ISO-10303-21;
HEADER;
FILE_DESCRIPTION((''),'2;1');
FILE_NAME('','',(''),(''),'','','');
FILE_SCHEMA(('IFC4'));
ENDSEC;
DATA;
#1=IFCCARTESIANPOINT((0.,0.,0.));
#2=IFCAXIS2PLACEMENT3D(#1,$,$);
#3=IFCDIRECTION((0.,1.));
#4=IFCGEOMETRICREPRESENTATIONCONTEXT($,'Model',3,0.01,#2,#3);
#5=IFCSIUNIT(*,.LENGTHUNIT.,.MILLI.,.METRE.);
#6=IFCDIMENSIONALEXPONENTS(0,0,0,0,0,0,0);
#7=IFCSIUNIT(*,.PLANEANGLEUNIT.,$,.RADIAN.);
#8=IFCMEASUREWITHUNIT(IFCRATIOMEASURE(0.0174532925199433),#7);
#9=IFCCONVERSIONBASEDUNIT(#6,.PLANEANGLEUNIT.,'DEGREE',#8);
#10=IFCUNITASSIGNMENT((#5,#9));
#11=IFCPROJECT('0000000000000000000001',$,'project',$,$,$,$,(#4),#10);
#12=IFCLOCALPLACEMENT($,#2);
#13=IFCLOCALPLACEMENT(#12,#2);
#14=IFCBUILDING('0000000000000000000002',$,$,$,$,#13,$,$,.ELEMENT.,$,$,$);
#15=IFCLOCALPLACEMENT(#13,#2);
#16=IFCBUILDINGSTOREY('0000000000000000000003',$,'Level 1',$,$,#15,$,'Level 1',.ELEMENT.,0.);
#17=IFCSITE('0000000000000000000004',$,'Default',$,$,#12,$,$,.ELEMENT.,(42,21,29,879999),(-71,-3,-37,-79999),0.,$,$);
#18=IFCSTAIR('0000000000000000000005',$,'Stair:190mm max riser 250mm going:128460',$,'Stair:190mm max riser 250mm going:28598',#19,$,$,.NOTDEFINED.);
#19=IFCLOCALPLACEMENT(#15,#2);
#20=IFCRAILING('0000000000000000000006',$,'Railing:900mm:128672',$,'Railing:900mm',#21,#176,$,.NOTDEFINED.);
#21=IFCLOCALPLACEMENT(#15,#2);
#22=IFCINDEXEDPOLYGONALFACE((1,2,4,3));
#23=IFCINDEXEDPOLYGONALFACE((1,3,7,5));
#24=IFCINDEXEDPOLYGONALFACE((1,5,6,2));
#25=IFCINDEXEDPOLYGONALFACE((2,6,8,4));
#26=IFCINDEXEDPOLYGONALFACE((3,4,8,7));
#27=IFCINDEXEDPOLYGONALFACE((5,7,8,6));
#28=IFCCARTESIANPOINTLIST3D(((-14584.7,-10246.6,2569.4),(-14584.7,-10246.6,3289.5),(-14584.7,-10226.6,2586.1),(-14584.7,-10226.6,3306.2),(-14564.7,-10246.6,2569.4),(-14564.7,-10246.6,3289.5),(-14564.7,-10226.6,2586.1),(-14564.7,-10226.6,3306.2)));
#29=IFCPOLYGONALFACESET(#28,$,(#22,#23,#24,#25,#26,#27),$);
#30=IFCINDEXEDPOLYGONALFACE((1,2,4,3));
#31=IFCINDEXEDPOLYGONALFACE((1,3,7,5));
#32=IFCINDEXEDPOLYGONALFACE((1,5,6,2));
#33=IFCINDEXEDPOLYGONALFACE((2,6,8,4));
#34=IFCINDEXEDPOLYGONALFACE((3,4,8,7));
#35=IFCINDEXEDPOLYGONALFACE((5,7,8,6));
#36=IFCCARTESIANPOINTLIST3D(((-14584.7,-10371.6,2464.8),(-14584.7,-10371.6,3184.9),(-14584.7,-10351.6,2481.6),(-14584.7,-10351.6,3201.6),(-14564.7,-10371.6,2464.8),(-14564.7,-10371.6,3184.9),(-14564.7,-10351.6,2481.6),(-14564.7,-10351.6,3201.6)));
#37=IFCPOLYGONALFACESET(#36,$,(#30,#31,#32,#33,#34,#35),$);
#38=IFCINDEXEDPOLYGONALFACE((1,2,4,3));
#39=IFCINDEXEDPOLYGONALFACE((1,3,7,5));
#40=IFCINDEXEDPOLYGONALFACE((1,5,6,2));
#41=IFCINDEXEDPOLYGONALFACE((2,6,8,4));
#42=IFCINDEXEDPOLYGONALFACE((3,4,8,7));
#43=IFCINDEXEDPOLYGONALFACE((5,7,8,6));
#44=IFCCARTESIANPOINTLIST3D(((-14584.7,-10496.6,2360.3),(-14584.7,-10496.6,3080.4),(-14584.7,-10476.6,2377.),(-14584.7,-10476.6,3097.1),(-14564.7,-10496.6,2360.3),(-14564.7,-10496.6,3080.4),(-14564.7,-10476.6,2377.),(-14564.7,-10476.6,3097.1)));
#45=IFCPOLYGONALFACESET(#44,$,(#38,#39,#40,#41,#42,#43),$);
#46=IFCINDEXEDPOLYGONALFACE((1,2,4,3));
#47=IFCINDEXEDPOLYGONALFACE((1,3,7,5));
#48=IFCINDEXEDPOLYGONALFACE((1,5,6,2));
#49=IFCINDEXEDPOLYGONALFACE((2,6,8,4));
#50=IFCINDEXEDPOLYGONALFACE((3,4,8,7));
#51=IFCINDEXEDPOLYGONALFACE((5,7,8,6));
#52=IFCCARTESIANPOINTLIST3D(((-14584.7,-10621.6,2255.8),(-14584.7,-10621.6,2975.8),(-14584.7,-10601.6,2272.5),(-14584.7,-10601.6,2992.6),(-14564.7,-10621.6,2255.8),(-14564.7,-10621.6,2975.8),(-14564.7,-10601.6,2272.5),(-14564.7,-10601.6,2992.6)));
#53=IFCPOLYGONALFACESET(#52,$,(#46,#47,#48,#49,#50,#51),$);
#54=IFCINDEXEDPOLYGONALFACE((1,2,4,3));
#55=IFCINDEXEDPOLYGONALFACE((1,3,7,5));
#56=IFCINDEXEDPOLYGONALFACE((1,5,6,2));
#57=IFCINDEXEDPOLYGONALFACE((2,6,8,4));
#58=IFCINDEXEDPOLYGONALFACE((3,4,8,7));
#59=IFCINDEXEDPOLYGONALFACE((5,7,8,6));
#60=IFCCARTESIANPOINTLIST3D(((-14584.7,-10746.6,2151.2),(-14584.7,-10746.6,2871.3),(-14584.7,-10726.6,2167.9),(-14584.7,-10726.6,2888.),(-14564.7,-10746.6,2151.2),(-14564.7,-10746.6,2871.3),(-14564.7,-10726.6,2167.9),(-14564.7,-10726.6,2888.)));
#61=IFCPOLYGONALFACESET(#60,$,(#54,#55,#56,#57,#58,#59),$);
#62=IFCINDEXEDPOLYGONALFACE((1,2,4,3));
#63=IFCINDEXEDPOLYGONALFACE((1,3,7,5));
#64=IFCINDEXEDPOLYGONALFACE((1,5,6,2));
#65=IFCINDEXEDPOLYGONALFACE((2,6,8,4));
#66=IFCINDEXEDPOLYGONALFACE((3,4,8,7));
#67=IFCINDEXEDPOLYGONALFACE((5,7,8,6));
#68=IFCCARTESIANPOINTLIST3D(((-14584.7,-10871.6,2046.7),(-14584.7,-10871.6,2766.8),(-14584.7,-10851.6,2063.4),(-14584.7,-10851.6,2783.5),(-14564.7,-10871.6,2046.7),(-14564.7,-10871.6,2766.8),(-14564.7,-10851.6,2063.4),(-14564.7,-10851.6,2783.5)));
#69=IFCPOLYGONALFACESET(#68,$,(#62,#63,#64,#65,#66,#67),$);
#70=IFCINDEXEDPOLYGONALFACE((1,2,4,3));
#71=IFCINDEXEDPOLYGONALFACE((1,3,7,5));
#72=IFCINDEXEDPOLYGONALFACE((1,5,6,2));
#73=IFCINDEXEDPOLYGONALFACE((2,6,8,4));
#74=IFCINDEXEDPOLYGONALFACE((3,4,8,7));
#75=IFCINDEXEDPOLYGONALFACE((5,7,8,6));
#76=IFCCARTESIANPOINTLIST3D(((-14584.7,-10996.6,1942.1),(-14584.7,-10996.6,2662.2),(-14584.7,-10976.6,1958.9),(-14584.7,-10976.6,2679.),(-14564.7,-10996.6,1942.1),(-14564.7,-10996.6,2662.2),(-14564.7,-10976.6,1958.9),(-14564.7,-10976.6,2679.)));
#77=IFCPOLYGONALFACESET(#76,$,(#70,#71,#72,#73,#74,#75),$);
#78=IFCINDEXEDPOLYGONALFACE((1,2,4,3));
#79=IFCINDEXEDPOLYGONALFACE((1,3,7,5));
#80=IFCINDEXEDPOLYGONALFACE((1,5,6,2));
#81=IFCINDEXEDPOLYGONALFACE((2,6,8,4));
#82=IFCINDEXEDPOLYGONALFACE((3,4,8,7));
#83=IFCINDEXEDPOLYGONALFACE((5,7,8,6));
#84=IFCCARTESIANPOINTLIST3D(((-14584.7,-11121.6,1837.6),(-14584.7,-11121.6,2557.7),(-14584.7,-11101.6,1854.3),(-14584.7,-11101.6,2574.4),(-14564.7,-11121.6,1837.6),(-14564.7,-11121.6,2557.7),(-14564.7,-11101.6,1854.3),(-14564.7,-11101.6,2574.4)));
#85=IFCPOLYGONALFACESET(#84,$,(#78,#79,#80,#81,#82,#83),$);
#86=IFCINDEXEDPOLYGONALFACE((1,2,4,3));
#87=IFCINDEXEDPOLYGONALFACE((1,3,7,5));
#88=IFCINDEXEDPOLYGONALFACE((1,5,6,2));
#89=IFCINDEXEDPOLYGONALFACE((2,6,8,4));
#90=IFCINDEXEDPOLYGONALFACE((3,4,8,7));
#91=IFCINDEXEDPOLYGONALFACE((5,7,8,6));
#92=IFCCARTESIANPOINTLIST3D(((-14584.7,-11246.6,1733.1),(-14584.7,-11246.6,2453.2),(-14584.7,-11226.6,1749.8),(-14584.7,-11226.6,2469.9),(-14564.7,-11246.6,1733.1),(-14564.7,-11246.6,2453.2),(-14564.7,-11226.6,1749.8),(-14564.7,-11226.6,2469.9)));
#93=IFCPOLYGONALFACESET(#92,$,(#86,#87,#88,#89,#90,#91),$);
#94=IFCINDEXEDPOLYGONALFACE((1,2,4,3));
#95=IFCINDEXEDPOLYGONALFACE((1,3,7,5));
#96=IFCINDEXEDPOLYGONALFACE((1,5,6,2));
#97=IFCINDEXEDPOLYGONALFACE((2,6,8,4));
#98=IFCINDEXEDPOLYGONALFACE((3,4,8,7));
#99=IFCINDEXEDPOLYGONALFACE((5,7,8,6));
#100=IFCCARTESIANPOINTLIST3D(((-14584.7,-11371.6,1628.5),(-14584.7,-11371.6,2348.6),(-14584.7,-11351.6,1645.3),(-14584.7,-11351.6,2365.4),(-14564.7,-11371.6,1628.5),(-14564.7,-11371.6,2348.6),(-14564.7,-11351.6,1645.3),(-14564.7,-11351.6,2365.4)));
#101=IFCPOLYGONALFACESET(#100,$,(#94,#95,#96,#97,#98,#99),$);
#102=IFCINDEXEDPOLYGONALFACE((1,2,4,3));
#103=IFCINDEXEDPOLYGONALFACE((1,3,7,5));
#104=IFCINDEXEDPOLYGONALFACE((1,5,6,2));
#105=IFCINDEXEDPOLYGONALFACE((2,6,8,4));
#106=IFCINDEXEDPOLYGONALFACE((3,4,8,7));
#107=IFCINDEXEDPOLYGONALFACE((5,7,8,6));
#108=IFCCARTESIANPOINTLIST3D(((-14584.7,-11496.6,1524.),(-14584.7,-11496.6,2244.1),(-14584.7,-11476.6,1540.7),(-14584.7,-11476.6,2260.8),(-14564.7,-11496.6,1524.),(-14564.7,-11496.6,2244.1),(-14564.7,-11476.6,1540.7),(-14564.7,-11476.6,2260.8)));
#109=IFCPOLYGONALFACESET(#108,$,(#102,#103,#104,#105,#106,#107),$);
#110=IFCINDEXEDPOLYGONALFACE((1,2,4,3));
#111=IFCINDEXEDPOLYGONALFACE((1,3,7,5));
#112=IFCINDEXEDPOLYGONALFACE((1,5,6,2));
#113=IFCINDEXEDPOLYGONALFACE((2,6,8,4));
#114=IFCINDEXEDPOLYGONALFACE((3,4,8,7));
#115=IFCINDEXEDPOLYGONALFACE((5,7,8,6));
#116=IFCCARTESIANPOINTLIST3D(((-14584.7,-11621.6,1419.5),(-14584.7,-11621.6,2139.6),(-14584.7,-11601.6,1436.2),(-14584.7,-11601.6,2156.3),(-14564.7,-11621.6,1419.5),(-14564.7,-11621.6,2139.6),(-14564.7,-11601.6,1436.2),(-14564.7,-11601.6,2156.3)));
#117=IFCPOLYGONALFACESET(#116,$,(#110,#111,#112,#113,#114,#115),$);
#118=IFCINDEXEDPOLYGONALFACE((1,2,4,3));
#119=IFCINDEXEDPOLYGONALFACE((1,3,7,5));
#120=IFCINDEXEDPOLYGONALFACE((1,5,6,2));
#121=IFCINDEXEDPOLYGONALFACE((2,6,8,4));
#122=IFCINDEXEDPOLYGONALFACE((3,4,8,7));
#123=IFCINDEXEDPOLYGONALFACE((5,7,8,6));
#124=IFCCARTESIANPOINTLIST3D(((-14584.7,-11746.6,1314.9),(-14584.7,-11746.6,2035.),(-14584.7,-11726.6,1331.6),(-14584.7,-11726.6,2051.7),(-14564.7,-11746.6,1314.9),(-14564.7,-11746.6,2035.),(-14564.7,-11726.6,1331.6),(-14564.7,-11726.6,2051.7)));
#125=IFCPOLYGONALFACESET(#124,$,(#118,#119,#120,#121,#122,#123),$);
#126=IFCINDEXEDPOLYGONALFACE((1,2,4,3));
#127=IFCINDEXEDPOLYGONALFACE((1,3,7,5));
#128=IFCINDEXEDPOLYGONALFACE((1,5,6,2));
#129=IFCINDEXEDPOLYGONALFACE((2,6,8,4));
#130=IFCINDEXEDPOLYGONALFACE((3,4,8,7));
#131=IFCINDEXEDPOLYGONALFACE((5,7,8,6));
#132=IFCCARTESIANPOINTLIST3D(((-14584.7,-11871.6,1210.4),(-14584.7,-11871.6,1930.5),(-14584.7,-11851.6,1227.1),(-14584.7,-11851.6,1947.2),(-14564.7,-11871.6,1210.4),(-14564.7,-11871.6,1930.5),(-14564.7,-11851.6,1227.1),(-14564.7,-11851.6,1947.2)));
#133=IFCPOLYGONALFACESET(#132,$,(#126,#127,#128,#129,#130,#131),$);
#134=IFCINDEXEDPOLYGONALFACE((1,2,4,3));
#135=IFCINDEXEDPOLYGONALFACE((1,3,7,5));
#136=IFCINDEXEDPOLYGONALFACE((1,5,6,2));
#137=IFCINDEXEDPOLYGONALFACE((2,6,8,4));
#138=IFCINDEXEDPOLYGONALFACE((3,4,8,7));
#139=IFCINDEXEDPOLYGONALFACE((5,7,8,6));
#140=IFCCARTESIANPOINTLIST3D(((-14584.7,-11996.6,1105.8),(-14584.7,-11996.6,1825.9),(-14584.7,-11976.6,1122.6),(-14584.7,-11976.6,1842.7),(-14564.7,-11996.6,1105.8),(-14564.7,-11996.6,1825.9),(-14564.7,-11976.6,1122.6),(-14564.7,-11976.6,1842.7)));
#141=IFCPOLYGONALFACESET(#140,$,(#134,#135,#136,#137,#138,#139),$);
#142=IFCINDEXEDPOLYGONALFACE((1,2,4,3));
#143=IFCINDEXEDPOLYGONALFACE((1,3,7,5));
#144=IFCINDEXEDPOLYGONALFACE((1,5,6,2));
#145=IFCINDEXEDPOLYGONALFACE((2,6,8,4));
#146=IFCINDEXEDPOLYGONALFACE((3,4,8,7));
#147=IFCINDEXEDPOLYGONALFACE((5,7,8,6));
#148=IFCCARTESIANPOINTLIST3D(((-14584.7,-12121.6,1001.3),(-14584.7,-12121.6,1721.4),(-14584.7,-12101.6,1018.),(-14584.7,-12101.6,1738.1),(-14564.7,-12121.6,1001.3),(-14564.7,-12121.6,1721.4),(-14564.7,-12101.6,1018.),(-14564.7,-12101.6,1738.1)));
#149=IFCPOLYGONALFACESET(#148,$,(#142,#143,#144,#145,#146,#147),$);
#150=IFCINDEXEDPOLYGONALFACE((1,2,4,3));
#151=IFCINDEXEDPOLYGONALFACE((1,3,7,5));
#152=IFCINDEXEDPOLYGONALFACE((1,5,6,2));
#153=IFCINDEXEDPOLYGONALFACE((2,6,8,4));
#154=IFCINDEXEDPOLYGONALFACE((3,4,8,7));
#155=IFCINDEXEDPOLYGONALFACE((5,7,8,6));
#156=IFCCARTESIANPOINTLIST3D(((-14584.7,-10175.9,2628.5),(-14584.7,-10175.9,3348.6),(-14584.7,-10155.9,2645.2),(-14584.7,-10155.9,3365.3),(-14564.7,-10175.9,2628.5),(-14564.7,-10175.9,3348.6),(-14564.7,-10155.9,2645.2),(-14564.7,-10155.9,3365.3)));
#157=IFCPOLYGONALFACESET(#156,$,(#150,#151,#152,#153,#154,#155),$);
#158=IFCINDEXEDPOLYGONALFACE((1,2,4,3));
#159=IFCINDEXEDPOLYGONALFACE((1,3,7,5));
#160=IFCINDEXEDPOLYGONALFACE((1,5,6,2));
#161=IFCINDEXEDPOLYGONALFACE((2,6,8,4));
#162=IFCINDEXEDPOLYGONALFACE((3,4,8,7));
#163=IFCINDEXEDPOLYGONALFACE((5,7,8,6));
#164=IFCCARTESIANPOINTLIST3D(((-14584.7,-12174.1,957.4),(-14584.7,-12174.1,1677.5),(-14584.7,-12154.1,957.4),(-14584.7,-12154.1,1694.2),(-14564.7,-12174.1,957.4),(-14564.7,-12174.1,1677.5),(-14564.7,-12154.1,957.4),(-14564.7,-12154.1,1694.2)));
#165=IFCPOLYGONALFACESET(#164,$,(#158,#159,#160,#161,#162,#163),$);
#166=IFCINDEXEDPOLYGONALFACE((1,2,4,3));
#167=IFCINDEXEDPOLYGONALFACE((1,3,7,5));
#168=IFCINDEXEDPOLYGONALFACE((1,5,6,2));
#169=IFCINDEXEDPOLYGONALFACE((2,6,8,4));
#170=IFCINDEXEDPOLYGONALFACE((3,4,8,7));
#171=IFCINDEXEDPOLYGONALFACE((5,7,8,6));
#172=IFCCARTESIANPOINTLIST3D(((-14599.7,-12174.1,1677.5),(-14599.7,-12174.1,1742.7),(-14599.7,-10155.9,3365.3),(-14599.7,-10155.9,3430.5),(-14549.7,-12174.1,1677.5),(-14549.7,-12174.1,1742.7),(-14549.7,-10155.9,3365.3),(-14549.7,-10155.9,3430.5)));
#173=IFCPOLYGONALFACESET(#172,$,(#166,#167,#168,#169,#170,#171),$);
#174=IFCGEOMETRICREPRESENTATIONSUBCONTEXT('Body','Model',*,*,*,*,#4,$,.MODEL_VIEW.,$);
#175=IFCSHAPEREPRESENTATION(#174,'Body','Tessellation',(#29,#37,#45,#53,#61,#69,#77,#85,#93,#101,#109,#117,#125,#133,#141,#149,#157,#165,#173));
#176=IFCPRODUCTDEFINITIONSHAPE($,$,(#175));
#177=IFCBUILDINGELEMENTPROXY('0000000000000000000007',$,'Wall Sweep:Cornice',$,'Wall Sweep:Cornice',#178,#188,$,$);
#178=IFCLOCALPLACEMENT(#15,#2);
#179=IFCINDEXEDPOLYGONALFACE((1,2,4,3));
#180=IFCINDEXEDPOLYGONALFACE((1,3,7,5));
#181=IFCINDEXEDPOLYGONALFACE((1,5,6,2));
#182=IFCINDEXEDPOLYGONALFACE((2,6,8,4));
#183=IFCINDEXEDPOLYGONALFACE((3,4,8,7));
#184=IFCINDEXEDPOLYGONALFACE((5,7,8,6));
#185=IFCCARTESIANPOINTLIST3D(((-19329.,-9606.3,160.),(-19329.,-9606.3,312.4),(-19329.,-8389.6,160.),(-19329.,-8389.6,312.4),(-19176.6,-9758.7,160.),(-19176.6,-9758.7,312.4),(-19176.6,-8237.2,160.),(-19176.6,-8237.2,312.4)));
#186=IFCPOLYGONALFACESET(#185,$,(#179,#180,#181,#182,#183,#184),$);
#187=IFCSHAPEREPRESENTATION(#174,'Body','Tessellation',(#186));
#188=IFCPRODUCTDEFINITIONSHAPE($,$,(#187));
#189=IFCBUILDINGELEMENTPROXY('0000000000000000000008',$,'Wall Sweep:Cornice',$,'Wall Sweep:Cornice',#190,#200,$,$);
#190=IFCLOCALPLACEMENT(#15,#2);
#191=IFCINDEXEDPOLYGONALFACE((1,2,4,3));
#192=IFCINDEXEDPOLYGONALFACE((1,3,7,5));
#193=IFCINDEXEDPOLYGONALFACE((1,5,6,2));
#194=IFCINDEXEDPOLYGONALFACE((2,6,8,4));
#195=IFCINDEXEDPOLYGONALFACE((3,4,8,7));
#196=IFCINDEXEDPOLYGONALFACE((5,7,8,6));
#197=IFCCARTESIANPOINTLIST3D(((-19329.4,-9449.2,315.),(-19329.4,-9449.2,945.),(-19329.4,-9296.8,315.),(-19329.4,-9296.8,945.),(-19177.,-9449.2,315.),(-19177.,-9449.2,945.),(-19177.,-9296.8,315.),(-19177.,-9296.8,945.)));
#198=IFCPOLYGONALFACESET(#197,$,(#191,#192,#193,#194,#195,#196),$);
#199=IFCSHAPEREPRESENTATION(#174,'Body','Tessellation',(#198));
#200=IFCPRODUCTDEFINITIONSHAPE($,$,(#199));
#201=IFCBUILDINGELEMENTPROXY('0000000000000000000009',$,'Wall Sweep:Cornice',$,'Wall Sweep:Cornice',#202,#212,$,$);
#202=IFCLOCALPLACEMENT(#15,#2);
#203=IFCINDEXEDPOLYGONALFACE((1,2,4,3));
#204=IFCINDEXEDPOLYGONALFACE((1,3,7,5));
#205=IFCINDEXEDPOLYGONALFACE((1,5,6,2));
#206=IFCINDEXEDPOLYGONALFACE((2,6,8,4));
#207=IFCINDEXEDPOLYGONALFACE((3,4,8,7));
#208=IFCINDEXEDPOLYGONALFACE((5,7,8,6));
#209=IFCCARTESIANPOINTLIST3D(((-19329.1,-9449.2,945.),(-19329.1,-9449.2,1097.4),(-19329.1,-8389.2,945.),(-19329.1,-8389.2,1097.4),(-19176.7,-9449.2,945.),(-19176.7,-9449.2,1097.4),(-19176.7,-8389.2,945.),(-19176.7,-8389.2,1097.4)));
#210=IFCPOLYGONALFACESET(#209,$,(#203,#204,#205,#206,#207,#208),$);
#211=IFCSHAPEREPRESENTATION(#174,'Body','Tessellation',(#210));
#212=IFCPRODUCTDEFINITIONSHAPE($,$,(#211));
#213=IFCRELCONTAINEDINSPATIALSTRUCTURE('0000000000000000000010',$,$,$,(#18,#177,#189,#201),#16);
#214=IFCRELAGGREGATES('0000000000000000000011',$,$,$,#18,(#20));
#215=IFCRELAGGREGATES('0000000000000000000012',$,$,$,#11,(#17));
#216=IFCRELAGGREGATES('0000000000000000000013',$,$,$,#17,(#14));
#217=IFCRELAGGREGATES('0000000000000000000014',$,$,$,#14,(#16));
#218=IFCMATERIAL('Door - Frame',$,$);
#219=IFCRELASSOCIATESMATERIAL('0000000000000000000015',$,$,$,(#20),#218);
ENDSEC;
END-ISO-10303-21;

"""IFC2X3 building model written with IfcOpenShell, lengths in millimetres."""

from ifc_helpers import new_model, entity, si_unit, converted_unit, direction, frame, frame_2d, origin, origin_2d_with_axis, place, context, subcontext, project, spatial, polyline, rectangle, outline, extrude, material, element, aggregate, save


model = new_model("IFC2X3")

# Units and contexts
model_context = context("Model", 3, precision=0.01, world=origin(), true_north=direction((0.0, 1.0)))
body_context = subcontext(model_context, "Body", "Model", "MODEL_VIEW")
ifc_project = project(units=[si_unit("LENGTHUNIT", "METRE", prefix="MILLI"), converted_unit("PLANEANGLEUNIT", "DEGREE", entity("IfcRatioMeasure", 0.0174532925199433), si_unit("PLANEANGLEUNIT", "RADIAN"), dimensions=[0, 0, 0, 0, 0, 0, 0])], contexts=[model_context])

# Site, building, storey
site_placement = place(None, origin())
site = spatial("IfcSite", under=ifc_project, at=site_placement, Name="Default", CompositionType="ELEMENT", RefLatitude=(42, 21, 29, 879999), RefLongitude=(-71, -3, -37, -79999), RefElevation=0.0)
building_placement = place(site_placement, origin())
building = spatial("IfcBuilding", under=site, at=building_placement, CompositionType="ELEMENT")
storey_placement = place(building_placement, origin())
storey = spatial("IfcBuildingStorey", under=building, at=storey_placement, Name="Level 1", LongName="Level 1", CompositionType="ELEMENT", Elevation=0.0)

# Shared definitions
ifc_material_1 = material(Name="Door - Frame")

# Stair
stair_1_placement = place(storey_placement, origin())
stair_1 = element("IfcStair", 1, at=stair_1_placement, inside=storey, Name="Stair:190mm max riser 250mm going:128460", ObjectType="Stair:190mm max riser 250mm going:28598", ShapeType="NOTDEFINED")

# Railing
railing_placement = place(stair_1_placement, origin())
railing = element("IfcRailing", 2, at=railing_placement, material=ifc_material_1, Name="Railing:900mm:128672", ObjectType="Railing:900mm", PredefinedType="NOTDEFINED", context=body_context, shape_type="SweptSolid", body=[
    extrude(outline(polyline([(-244.0, -276.2), (-217.9, -276.2), (244.0, 276.2), (217.9, 276.2), (-244.0, -276.2)])), frame((-14584.7, -10236.6, 2937.8), z_axis=(1.0, 0.0, 0.0), x_axis=(0.0, 0.767103, 0.641524)), (0.0, 0.0, 1.0), 20.0),
    extrude(outline(polyline([(-244.0, -276.2), (-217.9, -276.2), (244.0, 276.2), (217.9, 276.2), (-244.0, -276.2)])), frame((-14584.7, -10361.6, 2833.2), z_axis=(1.0, 0.0, 0.0), x_axis=(0.0, 0.767103, 0.641524)), (0.0, 0.0, 1.0), 20.0),
    extrude(outline(polyline([(-244.0, -276.2), (-217.9, -276.2), (244.0, 276.2), (217.9, 276.2), (-244.0, -276.2)])), frame((-14584.7, -10486.6, 2728.7), z_axis=(1.0, 0.0, 0.0), x_axis=(0.0, 0.767103, 0.641524)), (0.0, 0.0, 1.0), 20.0),
    extrude(outline(polyline([(-244.0, -276.2), (-217.9, -276.2), (244.0, 276.2), (217.9, 276.2), (-244.0, -276.2)])), frame((-14584.7, -10611.6, 2624.2), z_axis=(1.0, 0.0, 0.0), x_axis=(0.0, 0.767103, 0.641524)), (0.0, 0.0, 1.0), 20.0),
    extrude(outline(polyline([(-244.0, -276.2), (-217.9, -276.2), (244.0, 276.2), (217.9, 276.2), (-244.0, -276.2)])), frame((-14584.7, -10736.6, 2519.6), z_axis=(1.0, 0.0, 0.0), x_axis=(0.0, 0.767103, 0.641524)), (0.0, 0.0, 1.0), 20.0),
    extrude(outline(polyline([(-244.0, -276.2), (-217.9, -276.2), (244.0, 276.2), (217.9, 276.2), (-244.0, -276.2)])), frame((-14584.7, -10861.6, 2415.1), z_axis=(1.0, 0.0, 0.0), x_axis=(0.0, 0.767103, 0.641524)), (0.0, 0.0, 1.0), 20.0),
    extrude(outline(polyline([(-244.0, -276.2), (-217.9, -276.2), (244.0, 276.2), (217.9, 276.2), (-244.0, -276.2)])), frame((-14584.7, -10986.6, 2310.6), z_axis=(1.0, 0.0, 0.0), x_axis=(0.0, 0.767103, 0.641524)), (0.0, 0.0, 1.0), 20.0),
    extrude(outline(polyline([(-244.0, -276.2), (-217.9, -276.2), (244.0, 276.2), (217.9, 276.2), (-244.0, -276.2)])), frame((-14584.7, -11111.6, 2206.0), z_axis=(1.0, 0.0, 0.0), x_axis=(0.0, 0.767103, 0.641524)), (0.0, 0.0, 1.0), 20.0),
    extrude(outline(polyline([(-244.0, -276.2), (-217.9, -276.2), (244.0, 276.2), (217.9, 276.2), (-244.0, -276.2)])), frame((-14584.7, -11236.6, 2101.5), z_axis=(1.0, 0.0, 0.0), x_axis=(0.0, 0.767103, 0.641524)), (0.0, 0.0, 1.0), 20.0),
    extrude(outline(polyline([(-244.0, -276.2), (-217.9, -276.2), (244.0, 276.2), (217.9, 276.2), (-244.0, -276.2)])), frame((-14584.7, -11361.6, 1996.9), z_axis=(1.0, 0.0, 0.0), x_axis=(0.0, 0.767103, 0.641524)), (0.0, 0.0, 1.0), 20.0),
    extrude(outline(polyline([(-244.0, -276.2), (-217.9, -276.2), (244.0, 276.2), (217.9, 276.2), (-244.0, -276.2)])), frame((-14584.7, -11486.6, 1892.4), z_axis=(1.0, 0.0, 0.0), x_axis=(0.0, 0.767103, 0.641524)), (0.0, 0.0, 1.0), 20.0),
    extrude(outline(polyline([(-244.0, -276.2), (-217.9, -276.2), (244.0, 276.2), (217.9, 276.2), (-244.0, -276.2)])), frame((-14584.7, -11611.6, 1787.9), z_axis=(1.0, 0.0, 0.0), x_axis=(0.0, 0.767103, 0.641524)), (0.0, 0.0, 1.0), 20.0),
    extrude(outline(polyline([(-244.0, -276.2), (-217.9, -276.2), (244.0, 276.2), (217.9, 276.2), (-244.0, -276.2)])), frame((-14584.7, -11736.6, 1683.3), z_axis=(1.0, 0.0, 0.0), x_axis=(0.0, 0.767103, 0.641524)), (0.0, 0.0, 1.0), 20.0),
    extrude(outline(polyline([(-244.0, -276.2), (-217.9, -276.2), (244.0, 276.2), (217.9, 276.2), (-244.0, -276.2)])), frame((-14584.7, -11861.6, 1578.8), z_axis=(1.0, 0.0, 0.0), x_axis=(0.0, 0.767103, 0.641524)), (0.0, 0.0, 1.0), 20.0),
    extrude(outline(polyline([(-244.0, -276.2), (-217.9, -276.2), (244.0, 276.2), (217.9, 276.2), (-244.0, -276.2)])), frame((-14584.7, -11986.6, 1474.3), z_axis=(1.0, 0.0, 0.0), x_axis=(0.0, 0.767103, 0.641524)), (0.0, 0.0, 1.0), 20.0),
    extrude(outline(polyline([(-244.0, -276.2), (-217.9, -276.2), (244.0, 276.2), (217.9, 276.2), (-244.0, -276.2)])), frame((-14584.7, -12111.6, 1369.7), z_axis=(1.0, 0.0, 0.0), x_axis=(0.0, 0.767103, 0.641524)), (0.0, 0.0, 1.0), 20.0),
    extrude(outline(polyline([(-244.0, -276.2), (-217.9, -276.2), (244.0, 276.2), (217.9, 276.2), (-244.0, -276.2)])), frame((-14584.7, -10165.9, 2996.9), z_axis=(1.0, 0.0, 0.0), x_axis=(0.0, 0.767103, 0.641524)), (0.0, 0.0, 1.0), 20.0),
    extrude(outline(polyline([(-10.0, -364.2), (10.0, -364.2), (10.0, 372.6), (-10.0, 355.9), (-10.0, -364.2)])), frame((-14584.7, -12164.1, 1321.6), z_axis=(1.0, 0.0, 0.0), x_axis=(0.0, 1.0, 0.0)), (0.0, 0.0, 1.0), 20.0),
    extrude(outline(polyline([(-1336.4, -25.0), (1294.6, -25.0), (1336.4, 25.0), (-1294.6, 25.0), (-1336.4, -25.0)])), frame((-14599.7, -11165.0, 2554.0), z_axis=(1.0, 0.0, 0.0), x_axis=(0.0, 0.767103, 0.641524)), (0.0, 0.0, 1.0), 50.0),
])
aggregate(stair_1, [railing])

# Building element proxies
proxy_1_placement = place(storey_placement, origin())
element("IfcBuildingElementProxy", 3, at=proxy_1_placement, inside=storey, Name="Wall Sweep:Cornice", ObjectType="Wall Sweep:Cornice", context=body_context, shape_type="SweptSolid", body=[
    extrude(outline(polyline([(-760.8, -76.2), (760.8, -76.2), (608.4, 76.2), (-608.4, 76.2), (-760.8, -76.2)])), frame((-19252.8, -8998.0, 160.0), z_axis=(0.0, 0.0, 1.0), x_axis=(0.0, 1.0, 0.0)), (0.0, 0.0, 1.0), 152.4),
])
proxy_2_placement = place(storey_placement, origin())
element("IfcBuildingElementProxy", 4, at=proxy_2_placement, inside=storey, Name="Wall Sweep:Cornice", ObjectType="Wall Sweep:Cornice", context=body_context, shape_type="SweptSolid", body=[
    extrude(rectangle(XDim=152.4, YDim=152.4, at=origin_2d_with_axis()), frame((-19253.2, -9373.0, 315.0), z_axis=(0.0, 0.0, 1.0), x_axis=(0.0, -1.0, 0.0)), (0.0, 0.0, 1.0), 630.0),
])
proxy_3_placement = place(storey_placement, origin())
element("IfcBuildingElementProxy", 5, at=proxy_3_placement, inside=storey, Name="Wall Sweep:Cornice", ObjectType="Wall Sweep:Cornice", context=body_context, shape_type="SweptSolid", body=[
    extrude(rectangle(XDim=1060.0, YDim=152.4, at=frame_2d((0.0, 0.0), x_axis=(1.0, 0.0))), frame((-19252.9, -8919.2, 945.0), z_axis=(0.0, 0.0, 1.0), x_axis=(0.0, 1.0, 0.0)), (0.0, 0.0, 1.0), 152.4),
])

save(model, "model.ifc")
